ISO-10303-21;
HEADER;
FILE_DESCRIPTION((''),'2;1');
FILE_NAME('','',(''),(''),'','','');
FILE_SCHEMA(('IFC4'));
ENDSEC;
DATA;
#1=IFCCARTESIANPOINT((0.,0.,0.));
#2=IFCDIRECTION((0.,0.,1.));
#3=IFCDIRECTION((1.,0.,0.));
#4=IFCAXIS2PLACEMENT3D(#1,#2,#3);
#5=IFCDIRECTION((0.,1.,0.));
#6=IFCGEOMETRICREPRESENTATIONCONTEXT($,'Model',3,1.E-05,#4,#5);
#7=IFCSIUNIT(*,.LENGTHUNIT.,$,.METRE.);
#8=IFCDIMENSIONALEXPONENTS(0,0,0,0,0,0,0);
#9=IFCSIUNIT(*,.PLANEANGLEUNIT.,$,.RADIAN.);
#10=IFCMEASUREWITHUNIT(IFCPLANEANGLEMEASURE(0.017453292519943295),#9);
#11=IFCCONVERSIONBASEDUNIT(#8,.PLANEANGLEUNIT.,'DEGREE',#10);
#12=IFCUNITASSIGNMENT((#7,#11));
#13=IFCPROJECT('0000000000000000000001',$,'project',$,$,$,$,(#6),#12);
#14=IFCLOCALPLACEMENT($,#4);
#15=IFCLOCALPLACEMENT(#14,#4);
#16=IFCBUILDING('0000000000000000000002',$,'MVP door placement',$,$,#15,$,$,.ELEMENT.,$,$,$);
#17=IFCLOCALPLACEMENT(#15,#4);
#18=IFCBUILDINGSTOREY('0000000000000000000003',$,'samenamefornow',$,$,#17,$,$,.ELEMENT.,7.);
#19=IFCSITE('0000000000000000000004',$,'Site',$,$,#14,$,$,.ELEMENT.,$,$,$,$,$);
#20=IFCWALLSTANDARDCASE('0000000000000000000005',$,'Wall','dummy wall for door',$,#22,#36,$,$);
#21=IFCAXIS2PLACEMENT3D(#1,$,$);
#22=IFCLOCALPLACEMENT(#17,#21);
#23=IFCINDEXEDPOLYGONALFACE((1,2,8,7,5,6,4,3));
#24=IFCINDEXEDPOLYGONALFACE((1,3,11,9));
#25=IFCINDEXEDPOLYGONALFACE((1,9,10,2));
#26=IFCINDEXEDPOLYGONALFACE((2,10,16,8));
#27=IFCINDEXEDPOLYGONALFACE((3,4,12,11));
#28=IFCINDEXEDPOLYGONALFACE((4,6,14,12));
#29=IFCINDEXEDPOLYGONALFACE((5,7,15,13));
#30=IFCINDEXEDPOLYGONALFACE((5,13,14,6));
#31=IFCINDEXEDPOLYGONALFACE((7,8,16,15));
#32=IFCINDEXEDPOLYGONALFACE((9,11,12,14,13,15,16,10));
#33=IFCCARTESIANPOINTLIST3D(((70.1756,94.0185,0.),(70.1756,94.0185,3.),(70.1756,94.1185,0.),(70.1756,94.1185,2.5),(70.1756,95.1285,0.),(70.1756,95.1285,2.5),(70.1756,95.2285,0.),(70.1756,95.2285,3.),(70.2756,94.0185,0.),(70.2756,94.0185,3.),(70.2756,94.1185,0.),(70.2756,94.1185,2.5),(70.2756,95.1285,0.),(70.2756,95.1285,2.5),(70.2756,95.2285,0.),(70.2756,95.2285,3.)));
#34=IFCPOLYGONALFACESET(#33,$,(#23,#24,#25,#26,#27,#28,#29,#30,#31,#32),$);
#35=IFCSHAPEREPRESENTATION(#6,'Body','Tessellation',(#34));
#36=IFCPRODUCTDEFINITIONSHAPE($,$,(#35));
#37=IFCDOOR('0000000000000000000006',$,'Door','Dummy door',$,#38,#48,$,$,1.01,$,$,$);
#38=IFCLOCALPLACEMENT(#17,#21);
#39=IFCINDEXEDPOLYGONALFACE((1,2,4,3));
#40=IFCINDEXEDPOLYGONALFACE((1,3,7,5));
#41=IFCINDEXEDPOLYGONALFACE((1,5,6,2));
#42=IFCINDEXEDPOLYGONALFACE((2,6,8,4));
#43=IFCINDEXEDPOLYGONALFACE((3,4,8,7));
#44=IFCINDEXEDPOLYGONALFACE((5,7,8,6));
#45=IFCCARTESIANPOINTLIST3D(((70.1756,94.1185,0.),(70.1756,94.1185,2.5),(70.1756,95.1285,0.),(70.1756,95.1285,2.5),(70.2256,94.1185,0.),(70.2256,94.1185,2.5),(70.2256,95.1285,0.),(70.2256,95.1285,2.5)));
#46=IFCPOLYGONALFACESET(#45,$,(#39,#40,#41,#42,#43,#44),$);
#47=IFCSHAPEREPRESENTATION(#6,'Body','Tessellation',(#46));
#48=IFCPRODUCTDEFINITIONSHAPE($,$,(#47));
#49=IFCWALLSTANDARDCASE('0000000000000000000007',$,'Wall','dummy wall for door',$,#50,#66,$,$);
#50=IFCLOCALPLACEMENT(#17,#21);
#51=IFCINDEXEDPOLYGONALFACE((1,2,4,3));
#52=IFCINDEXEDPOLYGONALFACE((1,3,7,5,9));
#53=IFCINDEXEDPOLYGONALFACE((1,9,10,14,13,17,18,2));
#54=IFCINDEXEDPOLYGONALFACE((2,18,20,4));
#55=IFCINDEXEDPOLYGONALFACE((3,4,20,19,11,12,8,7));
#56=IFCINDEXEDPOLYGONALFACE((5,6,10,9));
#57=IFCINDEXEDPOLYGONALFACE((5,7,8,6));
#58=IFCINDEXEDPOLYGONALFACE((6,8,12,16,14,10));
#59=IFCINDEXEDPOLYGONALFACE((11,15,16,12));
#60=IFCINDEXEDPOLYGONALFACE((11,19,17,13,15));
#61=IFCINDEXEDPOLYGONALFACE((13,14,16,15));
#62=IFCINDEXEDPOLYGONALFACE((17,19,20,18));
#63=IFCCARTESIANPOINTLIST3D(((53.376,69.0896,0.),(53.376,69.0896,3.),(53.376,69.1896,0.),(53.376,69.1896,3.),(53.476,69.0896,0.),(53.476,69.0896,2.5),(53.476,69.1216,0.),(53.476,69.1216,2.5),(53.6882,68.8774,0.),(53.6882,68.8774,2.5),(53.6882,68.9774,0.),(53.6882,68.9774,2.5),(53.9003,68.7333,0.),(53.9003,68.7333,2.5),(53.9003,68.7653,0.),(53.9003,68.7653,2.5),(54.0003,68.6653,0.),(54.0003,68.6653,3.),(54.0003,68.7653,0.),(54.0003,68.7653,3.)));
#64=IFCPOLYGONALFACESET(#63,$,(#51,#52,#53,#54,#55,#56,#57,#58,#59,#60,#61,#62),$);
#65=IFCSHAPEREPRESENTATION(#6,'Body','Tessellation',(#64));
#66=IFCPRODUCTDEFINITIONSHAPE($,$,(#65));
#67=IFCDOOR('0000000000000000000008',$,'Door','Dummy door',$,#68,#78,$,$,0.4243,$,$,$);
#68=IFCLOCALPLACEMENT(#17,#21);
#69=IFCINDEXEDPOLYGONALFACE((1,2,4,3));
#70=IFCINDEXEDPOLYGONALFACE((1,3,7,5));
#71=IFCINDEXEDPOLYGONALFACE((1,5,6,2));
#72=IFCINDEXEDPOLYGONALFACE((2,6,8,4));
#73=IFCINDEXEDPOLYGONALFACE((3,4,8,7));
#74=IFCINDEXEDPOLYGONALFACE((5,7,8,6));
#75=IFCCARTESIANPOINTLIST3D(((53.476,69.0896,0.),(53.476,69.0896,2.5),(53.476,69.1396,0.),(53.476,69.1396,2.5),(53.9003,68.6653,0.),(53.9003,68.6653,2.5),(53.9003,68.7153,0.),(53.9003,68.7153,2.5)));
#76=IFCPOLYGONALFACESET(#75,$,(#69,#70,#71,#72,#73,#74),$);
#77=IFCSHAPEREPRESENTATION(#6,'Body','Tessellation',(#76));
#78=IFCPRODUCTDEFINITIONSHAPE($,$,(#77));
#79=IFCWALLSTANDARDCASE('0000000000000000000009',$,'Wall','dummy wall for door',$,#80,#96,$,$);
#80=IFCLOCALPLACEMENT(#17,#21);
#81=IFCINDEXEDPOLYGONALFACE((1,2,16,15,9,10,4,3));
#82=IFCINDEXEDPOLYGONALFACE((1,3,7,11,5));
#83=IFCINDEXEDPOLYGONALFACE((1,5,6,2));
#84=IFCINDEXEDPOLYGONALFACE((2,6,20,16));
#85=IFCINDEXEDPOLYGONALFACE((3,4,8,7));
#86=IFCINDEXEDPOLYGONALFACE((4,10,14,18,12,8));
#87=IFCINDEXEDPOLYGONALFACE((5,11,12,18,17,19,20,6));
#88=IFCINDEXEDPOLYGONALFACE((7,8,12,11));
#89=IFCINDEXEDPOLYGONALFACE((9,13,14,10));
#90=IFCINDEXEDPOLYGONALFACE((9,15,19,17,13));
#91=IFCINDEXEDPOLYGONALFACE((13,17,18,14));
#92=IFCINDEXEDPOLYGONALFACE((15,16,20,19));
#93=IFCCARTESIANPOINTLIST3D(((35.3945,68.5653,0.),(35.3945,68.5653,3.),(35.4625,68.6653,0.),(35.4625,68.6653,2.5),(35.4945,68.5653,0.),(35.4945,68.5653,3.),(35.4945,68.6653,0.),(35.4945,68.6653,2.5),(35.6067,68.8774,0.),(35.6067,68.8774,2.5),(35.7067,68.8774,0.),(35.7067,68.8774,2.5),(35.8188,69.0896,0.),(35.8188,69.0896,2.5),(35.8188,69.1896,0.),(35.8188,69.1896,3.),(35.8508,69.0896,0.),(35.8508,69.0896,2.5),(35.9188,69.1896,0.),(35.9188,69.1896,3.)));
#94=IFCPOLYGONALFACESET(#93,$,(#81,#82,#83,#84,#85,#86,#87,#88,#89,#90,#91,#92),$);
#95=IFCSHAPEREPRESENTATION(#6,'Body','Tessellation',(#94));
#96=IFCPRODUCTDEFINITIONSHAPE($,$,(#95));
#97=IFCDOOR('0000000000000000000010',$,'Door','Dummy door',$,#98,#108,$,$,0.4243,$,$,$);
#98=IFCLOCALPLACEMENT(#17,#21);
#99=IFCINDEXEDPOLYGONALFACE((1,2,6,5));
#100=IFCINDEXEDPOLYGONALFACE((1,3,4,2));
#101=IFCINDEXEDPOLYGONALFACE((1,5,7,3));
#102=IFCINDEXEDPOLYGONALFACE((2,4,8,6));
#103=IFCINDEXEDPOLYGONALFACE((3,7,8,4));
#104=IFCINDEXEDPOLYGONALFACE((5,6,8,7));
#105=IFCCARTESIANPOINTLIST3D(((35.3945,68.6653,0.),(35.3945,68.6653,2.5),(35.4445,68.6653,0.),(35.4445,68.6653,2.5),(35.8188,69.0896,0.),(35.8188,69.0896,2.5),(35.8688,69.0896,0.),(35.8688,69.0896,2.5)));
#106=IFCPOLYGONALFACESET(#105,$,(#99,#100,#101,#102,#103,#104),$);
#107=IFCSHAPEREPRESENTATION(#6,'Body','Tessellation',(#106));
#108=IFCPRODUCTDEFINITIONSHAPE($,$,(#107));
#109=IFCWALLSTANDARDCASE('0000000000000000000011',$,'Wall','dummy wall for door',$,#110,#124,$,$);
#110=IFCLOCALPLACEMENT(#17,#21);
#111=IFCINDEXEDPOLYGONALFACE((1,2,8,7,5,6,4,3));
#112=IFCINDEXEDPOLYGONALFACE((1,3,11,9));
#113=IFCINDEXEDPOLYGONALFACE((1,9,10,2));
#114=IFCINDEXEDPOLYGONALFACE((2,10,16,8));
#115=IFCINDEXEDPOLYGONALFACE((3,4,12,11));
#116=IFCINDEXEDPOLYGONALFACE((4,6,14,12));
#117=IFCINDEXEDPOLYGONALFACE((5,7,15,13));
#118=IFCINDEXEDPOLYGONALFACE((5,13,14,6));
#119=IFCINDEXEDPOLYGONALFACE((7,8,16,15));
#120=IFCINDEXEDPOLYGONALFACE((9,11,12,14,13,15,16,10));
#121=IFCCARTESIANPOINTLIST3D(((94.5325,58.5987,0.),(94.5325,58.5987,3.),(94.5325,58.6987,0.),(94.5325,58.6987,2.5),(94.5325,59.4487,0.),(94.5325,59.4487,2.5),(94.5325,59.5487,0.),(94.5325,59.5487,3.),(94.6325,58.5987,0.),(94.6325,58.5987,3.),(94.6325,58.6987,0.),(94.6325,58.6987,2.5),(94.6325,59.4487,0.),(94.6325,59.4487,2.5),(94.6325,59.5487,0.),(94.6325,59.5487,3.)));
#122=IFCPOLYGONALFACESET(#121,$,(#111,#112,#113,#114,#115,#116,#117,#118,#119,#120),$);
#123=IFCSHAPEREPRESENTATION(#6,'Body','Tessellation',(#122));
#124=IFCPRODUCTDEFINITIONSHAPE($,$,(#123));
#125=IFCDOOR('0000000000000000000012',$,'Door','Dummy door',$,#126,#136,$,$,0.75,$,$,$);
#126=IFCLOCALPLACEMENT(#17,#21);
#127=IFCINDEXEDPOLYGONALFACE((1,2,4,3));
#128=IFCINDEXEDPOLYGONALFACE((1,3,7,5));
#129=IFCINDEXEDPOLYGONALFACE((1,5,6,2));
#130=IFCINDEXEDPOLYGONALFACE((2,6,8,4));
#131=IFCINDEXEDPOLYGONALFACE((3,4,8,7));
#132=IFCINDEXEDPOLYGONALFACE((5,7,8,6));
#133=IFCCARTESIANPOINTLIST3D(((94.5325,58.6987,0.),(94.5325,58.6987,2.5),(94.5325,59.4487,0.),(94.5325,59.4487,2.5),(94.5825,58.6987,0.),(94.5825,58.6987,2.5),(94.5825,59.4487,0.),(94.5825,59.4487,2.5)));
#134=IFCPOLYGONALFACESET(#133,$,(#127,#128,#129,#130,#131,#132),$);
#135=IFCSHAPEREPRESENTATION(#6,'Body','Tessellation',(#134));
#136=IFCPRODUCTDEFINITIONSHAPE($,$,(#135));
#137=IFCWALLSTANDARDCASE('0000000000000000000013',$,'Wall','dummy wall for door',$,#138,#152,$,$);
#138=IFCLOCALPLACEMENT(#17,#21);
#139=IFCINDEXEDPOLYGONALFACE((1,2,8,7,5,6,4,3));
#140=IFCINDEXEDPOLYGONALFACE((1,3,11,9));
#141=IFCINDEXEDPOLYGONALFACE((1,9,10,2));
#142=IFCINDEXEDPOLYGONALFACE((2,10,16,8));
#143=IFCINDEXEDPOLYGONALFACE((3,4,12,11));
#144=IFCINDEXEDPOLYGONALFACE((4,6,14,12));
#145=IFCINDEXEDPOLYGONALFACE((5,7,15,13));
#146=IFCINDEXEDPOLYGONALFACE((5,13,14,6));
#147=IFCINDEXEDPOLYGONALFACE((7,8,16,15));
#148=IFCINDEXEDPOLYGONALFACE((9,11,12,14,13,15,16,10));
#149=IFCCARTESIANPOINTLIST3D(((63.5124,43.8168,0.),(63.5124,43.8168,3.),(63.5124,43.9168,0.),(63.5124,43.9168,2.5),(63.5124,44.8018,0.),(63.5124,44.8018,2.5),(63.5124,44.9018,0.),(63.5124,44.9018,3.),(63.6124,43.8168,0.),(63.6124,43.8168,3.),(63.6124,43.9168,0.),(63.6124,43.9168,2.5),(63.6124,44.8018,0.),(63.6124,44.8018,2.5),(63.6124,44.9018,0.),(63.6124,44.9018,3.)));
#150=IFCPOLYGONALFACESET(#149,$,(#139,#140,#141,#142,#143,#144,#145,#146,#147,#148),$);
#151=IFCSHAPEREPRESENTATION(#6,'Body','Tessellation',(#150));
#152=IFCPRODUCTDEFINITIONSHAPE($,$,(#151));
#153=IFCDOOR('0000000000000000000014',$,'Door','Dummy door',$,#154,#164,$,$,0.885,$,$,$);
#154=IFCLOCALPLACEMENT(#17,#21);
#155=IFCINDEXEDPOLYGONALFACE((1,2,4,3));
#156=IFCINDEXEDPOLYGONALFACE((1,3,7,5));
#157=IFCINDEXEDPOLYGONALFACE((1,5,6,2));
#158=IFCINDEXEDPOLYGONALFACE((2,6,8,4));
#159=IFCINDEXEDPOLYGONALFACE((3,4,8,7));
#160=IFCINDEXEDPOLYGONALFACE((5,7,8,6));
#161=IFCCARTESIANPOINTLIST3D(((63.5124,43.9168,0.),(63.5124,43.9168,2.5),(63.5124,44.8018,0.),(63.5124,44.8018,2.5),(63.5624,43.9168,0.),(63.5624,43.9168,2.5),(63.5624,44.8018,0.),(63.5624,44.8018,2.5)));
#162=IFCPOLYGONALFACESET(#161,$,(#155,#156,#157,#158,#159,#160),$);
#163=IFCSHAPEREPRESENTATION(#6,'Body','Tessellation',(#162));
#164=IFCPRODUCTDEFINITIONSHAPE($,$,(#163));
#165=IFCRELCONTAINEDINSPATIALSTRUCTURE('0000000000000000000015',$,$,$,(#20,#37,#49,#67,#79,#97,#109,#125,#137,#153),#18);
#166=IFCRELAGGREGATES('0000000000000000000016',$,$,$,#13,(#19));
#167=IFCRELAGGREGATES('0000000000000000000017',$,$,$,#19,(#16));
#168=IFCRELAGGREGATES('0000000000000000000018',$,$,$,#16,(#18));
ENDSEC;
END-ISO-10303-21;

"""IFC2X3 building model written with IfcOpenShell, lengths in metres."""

from ifc_helpers import new_model, entity, si_unit, converted_unit, direction, origin_with_axes, place, context, project, spatial, polyline, outline, extrude, element, fill, save


model = new_model("IFC2X3")

# Units and contexts
model_context = context("Model", 3, precision=1e-05, world=origin_with_axes(), true_north=direction((0.0, 1.0, 0.0)))
ifc_project = project(units=[si_unit("LENGTHUNIT", "METRE"), converted_unit("PLANEANGLEUNIT", "DEGREE", entity("IfcPlaneAngleMeasure", 0.017453292519943295), si_unit("PLANEANGLEUNIT", "RADIAN"), dimensions=[0, 0, 0, 0, 0, 0, 0])], contexts=[model_context])

# Site, building, storey
site_placement = place(None, origin_with_axes())
site = spatial("IfcSite", under=ifc_project, at=site_placement, Name="Site", CompositionType="ELEMENT")
building_placement = place(site_placement, origin_with_axes())
building = spatial("IfcBuilding", under=site, at=building_placement, Name="MVP door placement", CompositionType="ELEMENT")
storey_placement = place(building_placement, origin_with_axes())
storey = spatial("IfcBuildingStorey", under=building, at=storey_placement, Name="samenamefornow", CompositionType="ELEMENT", Elevation=7.0)

# Walls, openings, doors
wall_1_placement = place(storey_placement, origin_with_axes())
wall_1 = element("IfcWallStandardCase", 1, at=wall_1_placement, inside=storey, Name="Wall", Description="dummy wall for door", context=model_context, shape_type="SweptSolid", body=[
    extrude(outline(polyline([(70.1756, 94.0185, 0.0), (70.1756, 95.2285, 0.0), (70.2756, 95.2285, 0.0), (70.2756, 94.0185, 0.0), (70.1756, 94.0185, 0.0)])), origin_with_axes(), (0.0, 0.0, 1.0), 3.0),
])
opening_1_placement = place(wall_1_placement, origin_with_axes())
opening_1 = element("IfcOpeningElement", 2, at=opening_1_placement, cuts=wall_1, context=model_context, shape_type="SweptSolid", body=[
    extrude(outline(polyline([(70.1756, 94.1185, 0.0), (70.1756, 95.1285, 0.0), (70.2756, 95.1285, 0.0), (70.2756, 94.1185, 0.0), (70.1756, 94.1185, 0.0)])), origin_with_axes(), (0.0, 0.0, 1.0), 2.5),
])
door_1_placement = place(opening_1_placement, origin_with_axes())
door_1 = element("IfcDoor", 3, at=door_1_placement, inside=storey, Name="Door", Description="Dummy door", OverallWidth=1.01, context=model_context, shape_type="SweptSolid", body=[
    extrude(outline(polyline([(70.1756, 94.1185, 0.0), (70.1756, 95.1285, 0.0), (70.2256, 95.1285, 0.0), (70.2256, 94.1185, 0.0), (70.1756, 94.1185, 0.0)])), origin_with_axes(), (0.0, 0.0, 1.0), 2.5),
])
fill(opening_1, door_1)
wall_2_placement = place(storey_placement, origin_with_axes())
wall_2 = element("IfcWallStandardCase", 4, at=wall_2_placement, inside=storey, Name="Wall", Description="dummy wall for door", context=model_context, shape_type="SweptSolid", body=[
    extrude(outline(polyline([(53.376, 69.0896, 0.0), (54.0003, 68.6653, 0.0), (54.0003, 68.7653, 0.0), (53.376, 69.1896, 0.0), (53.376, 69.0896, 0.0)])), origin_with_axes(), (0.0, 0.0, 1.0), 3.0),
])
opening_2_placement = place(wall_2_placement, origin_with_axes())
opening_2 = element("IfcOpeningElement", 5, at=opening_2_placement, cuts=wall_2, context=model_context, shape_type="SweptSolid", body=[
    extrude(outline(polyline([(53.476, 69.0896, 0.0), (53.9003, 68.6653, 0.0), (53.9003, 68.7653, 0.0), (53.476, 69.1896, 0.0), (53.476, 69.0896, 0.0)])), origin_with_axes(), (0.0, 0.0, 1.0), 2.5),
])
door_2_placement = place(opening_2_placement, origin_with_axes())
door_2 = element("IfcDoor", 6, at=door_2_placement, inside=storey, Name="Door", Description="Dummy door", OverallWidth=0.4243, context=model_context, shape_type="SweptSolid", body=[
    extrude(outline(polyline([(53.476, 69.0896, 0.0), (53.9003, 68.6653, 0.0), (53.9003, 68.7153, 0.0), (53.476, 69.1396, 0.0), (53.476, 69.0896, 0.0)])), origin_with_axes(), (0.0, 0.0, 1.0), 2.5),
])
fill(opening_2, door_2)
wall_3_placement = place(storey_placement, origin_with_axes())
wall_3 = element("IfcWallStandardCase", 7, at=wall_3_placement, inside=storey, Name="Wall", Description="dummy wall for door", context=model_context, shape_type="SweptSolid", body=[
    extrude(outline(polyline([(35.8188, 69.1896, 0.0), (35.3945, 68.5653, 0.0), (35.4945, 68.5653, 0.0), (35.9188, 69.1896, 0.0), (35.8188, 69.1896, 0.0)])), origin_with_axes(), (0.0, 0.0, 1.0), 3.0),
])
opening_3_placement = place(wall_3_placement, origin_with_axes())
opening_3 = element("IfcOpeningElement", 8, at=opening_3_placement, cuts=wall_3, context=model_context, shape_type="SweptSolid", body=[
    extrude(outline(polyline([(35.8188, 69.0896, 0.0), (35.3945, 68.6653, 0.0), (35.4945, 68.6653, 0.0), (35.9188, 69.0896, 0.0), (35.8188, 69.0896, 0.0)])), origin_with_axes(), (0.0, 0.0, 1.0), 2.5),
])
door_3_placement = place(opening_3_placement, origin_with_axes())
door_3 = element("IfcDoor", 9, at=door_3_placement, inside=storey, Name="Door", Description="Dummy door", OverallWidth=0.4243, context=model_context, shape_type="SweptSolid", body=[
    extrude(outline(polyline([(35.8188, 69.0896, 0.0), (35.3945, 68.6653, 0.0), (35.4445, 68.6653, 0.0), (35.8688, 69.0896, 0.0), (35.8188, 69.0896, 0.0)])), origin_with_axes(), (0.0, 0.0, 1.0), 2.5),
])
fill(opening_3, door_3)
wall_4_placement = place(storey_placement, origin_with_axes())
wall_4 = element("IfcWallStandardCase", 10, at=wall_4_placement, inside=storey, Name="Wall", Description="dummy wall for door", context=model_context, shape_type="SweptSolid", body=[
    extrude(outline(polyline([(94.5325, 58.5987, 0.0), (94.5325, 59.5487, 0.0), (94.6325, 59.5487, 0.0), (94.6325, 58.5987, 0.0), (94.5325, 58.5987, 0.0)])), origin_with_axes(), (0.0, 0.0, 1.0), 3.0),
])
opening_4_placement = place(wall_4_placement, origin_with_axes())
opening_4 = element("IfcOpeningElement", 11, at=opening_4_placement, cuts=wall_4, context=model_context, shape_type="SweptSolid", body=[
    extrude(outline(polyline([(94.5325, 58.6987, 0.0), (94.5325, 59.4487, 0.0), (94.6325, 59.4487, 0.0), (94.6325, 58.6987, 0.0), (94.5325, 58.6987, 0.0)])), origin_with_axes(), (0.0, 0.0, 1.0), 2.5),
])
door_4_placement = place(opening_4_placement, origin_with_axes())
door_4 = element("IfcDoor", 12, at=door_4_placement, inside=storey, Name="Door", Description="Dummy door", OverallWidth=0.75, context=model_context, shape_type="SweptSolid", body=[
    extrude(outline(polyline([(94.5325, 58.6987, 0.0), (94.5325, 59.4487, 0.0), (94.5825, 59.4487, 0.0), (94.5825, 58.6987, 0.0), (94.5325, 58.6987, 0.0)])), origin_with_axes(), (0.0, 0.0, 1.0), 2.5),
])
fill(opening_4, door_4)
wall_5_placement = place(storey_placement, origin_with_axes())
wall_5 = element("IfcWallStandardCase", 13, at=wall_5_placement, inside=storey, Name="Wall", Description="dummy wall for door", context=model_context, shape_type="SweptSolid", body=[
    extrude(outline(polyline([(63.5124, 44.9018, 0.0), (63.5124, 43.8168, 0.0), (63.6124, 43.8168, 0.0), (63.6124, 44.9018, 0.0), (63.5124, 44.9018, 0.0)])), origin_with_axes(), (0.0, 0.0, 1.0), 3.0),
])
opening_5_placement = place(wall_5_placement, origin_with_axes())
opening_5 = element("IfcOpeningElement", 14, at=opening_5_placement, cuts=wall_5, context=model_context, shape_type="SweptSolid", body=[
    extrude(outline(polyline([(63.5124, 44.8018, 0.0), (63.5124, 43.9168, 0.0), (63.6124, 43.9168, 0.0), (63.6124, 44.8018, 0.0), (63.5124, 44.8018, 0.0)])), origin_with_axes(), (0.0, 0.0, 1.0), 2.5),
])
door_5_placement = place(opening_5_placement, origin_with_axes())
door_5 = element("IfcDoor", 15, at=door_5_placement, inside=storey, Name="Door", Description="Dummy door", OverallWidth=0.885, context=model_context, shape_type="SweptSolid", body=[
    extrude(outline(polyline([(63.5124, 44.8018, 0.0), (63.5124, 43.9168, 0.0), (63.5624, 43.9168, 0.0), (63.5624, 44.8018, 0.0), (63.5124, 44.8018, 0.0)])), origin_with_axes(), (0.0, 0.0, 1.0), 2.5),
])
fill(opening_5, door_5)

save(model, "model.ifc")
